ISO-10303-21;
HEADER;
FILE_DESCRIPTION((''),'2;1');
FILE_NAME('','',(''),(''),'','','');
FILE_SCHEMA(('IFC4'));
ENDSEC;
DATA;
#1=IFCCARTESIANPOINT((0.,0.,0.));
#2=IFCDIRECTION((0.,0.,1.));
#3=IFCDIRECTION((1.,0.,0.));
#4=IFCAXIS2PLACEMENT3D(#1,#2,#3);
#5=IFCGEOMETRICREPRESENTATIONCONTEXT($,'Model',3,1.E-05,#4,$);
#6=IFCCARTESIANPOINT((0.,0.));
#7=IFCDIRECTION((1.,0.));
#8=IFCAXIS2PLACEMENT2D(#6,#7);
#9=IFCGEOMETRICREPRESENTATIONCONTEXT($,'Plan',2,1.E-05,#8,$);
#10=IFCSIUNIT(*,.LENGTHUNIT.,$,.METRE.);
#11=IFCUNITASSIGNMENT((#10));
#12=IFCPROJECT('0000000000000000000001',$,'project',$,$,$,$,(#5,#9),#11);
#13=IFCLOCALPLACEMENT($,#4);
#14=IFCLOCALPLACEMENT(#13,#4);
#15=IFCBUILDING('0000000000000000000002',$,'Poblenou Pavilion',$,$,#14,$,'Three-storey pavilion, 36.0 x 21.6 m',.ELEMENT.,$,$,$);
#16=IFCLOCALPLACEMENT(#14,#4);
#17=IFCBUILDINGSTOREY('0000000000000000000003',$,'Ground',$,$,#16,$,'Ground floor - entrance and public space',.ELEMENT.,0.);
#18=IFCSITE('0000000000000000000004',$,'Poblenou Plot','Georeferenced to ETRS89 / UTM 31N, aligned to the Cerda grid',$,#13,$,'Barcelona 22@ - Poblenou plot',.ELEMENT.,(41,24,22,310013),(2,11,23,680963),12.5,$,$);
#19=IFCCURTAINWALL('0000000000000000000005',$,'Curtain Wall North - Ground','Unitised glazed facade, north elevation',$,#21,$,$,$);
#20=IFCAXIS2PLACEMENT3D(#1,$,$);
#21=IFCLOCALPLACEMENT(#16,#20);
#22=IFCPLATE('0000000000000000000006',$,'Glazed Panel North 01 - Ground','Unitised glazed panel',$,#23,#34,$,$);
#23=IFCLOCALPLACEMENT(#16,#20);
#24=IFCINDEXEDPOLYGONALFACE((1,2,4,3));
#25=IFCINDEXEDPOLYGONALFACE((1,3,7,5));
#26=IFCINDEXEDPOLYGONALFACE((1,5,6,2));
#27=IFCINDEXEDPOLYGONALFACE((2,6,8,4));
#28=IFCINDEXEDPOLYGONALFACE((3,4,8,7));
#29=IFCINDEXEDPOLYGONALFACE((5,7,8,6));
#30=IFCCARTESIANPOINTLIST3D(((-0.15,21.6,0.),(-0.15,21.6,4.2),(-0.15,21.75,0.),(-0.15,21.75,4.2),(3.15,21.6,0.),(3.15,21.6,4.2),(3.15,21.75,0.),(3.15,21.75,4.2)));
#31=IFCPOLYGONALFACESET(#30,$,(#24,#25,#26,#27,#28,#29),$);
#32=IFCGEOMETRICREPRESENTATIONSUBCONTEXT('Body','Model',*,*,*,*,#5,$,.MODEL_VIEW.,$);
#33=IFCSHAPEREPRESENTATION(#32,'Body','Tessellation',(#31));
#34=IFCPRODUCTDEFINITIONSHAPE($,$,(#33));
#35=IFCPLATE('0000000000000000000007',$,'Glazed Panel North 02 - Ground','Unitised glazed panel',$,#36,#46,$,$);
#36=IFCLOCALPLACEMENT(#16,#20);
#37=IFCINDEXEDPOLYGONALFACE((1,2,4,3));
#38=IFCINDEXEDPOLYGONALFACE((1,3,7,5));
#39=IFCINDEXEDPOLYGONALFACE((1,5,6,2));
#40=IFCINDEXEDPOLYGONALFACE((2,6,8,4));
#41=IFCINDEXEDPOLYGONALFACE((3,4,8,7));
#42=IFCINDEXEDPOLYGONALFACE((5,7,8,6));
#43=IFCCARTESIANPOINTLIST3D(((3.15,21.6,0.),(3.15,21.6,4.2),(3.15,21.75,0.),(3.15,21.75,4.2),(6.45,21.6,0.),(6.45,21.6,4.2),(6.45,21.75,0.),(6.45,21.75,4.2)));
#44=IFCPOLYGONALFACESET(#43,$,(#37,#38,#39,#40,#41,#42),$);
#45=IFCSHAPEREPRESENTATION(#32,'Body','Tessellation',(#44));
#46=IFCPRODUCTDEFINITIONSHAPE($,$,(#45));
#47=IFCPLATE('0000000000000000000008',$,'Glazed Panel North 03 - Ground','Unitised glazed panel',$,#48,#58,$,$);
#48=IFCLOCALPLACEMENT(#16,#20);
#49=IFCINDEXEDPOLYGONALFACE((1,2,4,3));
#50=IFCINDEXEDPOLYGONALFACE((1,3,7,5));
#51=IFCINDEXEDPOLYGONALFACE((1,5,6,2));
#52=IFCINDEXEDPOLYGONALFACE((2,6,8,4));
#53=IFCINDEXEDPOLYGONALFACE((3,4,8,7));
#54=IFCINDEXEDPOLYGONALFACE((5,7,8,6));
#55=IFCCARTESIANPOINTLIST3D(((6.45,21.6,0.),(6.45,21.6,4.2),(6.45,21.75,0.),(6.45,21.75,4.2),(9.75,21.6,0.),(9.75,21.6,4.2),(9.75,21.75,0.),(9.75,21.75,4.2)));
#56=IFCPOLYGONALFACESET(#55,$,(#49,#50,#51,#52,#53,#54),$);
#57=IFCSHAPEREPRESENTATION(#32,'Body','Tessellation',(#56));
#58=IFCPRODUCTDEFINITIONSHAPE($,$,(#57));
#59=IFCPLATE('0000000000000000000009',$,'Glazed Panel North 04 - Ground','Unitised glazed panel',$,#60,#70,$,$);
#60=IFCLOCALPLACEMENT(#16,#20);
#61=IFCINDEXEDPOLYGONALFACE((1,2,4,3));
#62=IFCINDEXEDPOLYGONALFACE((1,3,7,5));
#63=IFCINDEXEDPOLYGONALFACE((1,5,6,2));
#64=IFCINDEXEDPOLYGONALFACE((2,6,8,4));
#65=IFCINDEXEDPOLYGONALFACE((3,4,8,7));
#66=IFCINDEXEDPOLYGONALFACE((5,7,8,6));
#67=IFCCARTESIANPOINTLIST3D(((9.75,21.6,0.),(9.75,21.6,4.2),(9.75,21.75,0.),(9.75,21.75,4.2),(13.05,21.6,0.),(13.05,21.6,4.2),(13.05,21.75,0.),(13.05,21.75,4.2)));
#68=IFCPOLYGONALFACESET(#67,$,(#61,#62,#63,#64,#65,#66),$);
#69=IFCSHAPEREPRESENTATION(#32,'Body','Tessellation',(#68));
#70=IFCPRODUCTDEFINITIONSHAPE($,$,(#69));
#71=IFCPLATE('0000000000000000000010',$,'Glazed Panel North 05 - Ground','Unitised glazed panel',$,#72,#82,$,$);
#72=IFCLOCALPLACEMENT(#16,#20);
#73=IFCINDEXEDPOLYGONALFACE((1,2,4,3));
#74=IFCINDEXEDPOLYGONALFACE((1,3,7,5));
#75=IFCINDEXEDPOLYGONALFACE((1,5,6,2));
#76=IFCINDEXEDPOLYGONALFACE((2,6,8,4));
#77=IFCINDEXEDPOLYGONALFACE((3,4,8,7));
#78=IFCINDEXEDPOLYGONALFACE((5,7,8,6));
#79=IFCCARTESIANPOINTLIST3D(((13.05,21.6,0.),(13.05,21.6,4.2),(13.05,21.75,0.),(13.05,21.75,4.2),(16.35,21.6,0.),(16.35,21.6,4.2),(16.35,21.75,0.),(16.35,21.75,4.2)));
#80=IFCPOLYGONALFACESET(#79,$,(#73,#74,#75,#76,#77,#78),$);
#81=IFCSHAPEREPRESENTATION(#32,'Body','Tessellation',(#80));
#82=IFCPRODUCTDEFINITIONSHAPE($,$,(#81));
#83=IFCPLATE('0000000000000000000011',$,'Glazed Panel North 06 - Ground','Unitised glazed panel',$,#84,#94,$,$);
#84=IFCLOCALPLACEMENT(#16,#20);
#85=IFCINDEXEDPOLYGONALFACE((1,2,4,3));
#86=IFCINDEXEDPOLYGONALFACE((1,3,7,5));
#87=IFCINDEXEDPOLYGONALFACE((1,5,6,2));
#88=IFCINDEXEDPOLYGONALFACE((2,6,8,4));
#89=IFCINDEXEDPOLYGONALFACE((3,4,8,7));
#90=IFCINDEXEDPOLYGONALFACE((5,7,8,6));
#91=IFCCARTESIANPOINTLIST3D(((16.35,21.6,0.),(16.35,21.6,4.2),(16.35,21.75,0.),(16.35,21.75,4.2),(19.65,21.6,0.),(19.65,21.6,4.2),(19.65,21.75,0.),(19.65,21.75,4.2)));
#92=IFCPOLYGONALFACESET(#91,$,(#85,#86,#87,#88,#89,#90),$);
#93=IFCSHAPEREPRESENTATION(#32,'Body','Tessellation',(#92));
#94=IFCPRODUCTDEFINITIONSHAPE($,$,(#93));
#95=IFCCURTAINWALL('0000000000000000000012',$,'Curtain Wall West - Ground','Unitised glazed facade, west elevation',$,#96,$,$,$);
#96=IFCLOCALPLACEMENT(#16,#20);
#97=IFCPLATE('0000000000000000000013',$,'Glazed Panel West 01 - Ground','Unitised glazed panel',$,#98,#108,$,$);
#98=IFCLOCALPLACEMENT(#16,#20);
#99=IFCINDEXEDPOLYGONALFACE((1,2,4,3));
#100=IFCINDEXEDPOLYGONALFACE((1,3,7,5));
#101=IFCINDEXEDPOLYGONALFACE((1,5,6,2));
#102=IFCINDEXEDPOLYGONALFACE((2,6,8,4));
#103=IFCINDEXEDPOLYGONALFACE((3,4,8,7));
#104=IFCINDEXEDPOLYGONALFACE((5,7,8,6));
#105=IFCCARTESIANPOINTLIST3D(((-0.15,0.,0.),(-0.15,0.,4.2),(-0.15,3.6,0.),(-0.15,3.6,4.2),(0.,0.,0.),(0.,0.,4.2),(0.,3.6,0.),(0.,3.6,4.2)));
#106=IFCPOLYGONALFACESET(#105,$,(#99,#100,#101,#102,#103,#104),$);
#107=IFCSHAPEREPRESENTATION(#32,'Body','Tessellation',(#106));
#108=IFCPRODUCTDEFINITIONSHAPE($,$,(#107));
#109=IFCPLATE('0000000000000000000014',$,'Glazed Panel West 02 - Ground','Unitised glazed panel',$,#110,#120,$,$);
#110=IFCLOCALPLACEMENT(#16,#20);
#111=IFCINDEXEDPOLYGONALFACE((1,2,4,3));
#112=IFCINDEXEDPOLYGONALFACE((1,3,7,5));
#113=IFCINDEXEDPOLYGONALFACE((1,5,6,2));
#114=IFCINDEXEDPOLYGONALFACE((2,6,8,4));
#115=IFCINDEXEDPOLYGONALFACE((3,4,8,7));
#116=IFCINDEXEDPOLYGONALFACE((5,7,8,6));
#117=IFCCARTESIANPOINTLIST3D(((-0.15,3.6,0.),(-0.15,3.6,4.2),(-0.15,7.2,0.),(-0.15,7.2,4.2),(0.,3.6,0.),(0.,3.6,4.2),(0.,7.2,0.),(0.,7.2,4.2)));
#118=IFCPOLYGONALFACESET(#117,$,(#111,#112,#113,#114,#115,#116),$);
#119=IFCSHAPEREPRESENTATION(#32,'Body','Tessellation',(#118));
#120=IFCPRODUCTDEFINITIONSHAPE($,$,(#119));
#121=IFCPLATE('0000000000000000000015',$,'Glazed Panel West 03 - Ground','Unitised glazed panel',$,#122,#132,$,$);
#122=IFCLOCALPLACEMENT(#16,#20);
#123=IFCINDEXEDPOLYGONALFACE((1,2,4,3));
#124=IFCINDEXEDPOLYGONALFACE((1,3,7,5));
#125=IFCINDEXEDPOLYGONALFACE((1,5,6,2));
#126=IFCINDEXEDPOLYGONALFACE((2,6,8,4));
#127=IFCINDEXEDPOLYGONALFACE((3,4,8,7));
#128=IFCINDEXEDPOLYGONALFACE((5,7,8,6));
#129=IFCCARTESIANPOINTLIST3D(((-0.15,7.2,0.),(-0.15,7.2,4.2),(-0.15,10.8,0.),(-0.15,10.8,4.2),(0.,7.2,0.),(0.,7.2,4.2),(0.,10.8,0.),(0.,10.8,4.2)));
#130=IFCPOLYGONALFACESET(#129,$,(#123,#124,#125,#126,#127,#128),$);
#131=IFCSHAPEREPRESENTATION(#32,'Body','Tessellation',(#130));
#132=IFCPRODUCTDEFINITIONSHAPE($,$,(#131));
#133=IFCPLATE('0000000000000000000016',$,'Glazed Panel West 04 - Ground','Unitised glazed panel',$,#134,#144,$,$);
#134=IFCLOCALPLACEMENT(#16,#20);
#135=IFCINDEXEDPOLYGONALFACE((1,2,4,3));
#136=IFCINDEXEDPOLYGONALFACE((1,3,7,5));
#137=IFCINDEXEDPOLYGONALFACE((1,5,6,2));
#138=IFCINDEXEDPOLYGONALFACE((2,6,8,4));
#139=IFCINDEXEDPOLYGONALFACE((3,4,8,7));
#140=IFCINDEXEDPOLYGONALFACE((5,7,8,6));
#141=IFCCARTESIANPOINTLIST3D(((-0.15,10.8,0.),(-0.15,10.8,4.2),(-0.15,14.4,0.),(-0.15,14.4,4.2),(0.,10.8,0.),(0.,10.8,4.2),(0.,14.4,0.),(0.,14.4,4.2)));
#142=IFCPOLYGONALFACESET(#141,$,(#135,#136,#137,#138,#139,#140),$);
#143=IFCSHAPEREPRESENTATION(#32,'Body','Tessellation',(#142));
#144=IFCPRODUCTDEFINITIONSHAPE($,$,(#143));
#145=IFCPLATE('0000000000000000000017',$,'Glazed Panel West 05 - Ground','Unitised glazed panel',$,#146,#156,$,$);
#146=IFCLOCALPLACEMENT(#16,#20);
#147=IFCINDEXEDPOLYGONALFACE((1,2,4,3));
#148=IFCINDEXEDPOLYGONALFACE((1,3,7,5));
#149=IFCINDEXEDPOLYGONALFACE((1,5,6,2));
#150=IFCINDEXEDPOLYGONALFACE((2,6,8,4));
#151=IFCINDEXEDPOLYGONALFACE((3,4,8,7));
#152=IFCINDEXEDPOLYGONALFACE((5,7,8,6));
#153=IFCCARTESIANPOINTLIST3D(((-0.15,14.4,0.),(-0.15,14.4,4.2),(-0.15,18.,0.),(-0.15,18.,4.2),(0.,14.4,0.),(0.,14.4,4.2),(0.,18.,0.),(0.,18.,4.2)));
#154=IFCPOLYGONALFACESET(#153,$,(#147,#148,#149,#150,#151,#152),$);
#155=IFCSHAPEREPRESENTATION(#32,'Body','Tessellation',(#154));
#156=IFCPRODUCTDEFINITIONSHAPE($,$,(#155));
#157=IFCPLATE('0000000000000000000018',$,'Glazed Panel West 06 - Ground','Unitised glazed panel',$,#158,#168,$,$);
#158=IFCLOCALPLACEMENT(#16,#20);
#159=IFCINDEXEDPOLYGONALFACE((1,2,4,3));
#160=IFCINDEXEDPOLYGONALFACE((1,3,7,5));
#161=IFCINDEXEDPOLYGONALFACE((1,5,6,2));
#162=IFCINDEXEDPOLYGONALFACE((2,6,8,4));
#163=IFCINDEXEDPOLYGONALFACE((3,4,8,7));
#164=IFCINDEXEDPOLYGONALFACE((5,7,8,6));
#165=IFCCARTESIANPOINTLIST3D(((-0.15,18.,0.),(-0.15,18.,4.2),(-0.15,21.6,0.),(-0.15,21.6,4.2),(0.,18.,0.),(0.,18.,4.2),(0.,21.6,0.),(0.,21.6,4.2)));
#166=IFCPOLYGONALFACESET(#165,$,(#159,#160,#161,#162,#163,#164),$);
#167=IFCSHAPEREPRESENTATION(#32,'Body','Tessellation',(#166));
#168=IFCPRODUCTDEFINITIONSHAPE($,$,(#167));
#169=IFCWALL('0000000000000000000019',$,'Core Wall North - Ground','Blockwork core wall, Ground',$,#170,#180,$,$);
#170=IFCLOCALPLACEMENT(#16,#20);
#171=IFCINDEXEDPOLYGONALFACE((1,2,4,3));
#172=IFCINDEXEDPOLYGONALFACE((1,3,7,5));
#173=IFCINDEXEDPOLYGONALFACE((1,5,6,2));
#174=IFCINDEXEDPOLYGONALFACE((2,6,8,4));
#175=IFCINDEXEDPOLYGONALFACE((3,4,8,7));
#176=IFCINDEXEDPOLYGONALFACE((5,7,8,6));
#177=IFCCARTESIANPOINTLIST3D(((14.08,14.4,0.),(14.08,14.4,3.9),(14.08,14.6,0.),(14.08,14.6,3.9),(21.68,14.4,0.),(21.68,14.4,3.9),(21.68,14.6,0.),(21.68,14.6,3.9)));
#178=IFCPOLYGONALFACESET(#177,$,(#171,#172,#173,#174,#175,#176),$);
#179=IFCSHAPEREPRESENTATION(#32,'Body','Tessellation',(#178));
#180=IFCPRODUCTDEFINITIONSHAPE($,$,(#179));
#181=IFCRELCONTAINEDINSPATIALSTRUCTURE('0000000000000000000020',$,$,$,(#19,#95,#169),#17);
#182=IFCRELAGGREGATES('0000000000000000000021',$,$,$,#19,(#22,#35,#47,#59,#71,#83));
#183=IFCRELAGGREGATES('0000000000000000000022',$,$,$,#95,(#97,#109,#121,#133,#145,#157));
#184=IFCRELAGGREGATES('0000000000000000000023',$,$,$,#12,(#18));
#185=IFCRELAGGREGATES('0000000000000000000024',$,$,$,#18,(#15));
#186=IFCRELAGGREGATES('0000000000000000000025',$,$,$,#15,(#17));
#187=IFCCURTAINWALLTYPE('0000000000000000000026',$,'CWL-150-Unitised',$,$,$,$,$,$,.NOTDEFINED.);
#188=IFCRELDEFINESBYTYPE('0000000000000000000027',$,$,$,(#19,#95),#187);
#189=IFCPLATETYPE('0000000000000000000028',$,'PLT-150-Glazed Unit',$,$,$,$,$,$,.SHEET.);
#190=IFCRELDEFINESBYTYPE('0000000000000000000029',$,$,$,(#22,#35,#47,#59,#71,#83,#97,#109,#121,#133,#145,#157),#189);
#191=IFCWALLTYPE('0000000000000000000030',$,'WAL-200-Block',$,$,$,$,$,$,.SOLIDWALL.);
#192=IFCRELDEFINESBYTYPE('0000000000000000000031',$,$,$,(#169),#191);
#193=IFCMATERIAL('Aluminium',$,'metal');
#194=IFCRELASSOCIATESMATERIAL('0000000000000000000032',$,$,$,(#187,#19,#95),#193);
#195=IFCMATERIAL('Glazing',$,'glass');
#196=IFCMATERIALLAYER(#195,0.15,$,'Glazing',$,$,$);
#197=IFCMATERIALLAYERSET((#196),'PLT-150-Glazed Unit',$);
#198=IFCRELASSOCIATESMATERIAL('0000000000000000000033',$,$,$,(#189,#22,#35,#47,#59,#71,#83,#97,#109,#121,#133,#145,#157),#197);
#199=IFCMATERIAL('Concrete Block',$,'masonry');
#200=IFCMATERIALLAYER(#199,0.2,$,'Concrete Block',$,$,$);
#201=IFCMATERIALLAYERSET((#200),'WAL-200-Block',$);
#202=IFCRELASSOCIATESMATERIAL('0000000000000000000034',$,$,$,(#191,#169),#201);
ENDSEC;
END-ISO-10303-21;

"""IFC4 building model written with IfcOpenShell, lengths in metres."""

from ifc_helpers import new_model, si_unit, frame, origin_with_axes, origin_2d_with_axis, place, context, subcontext, project, spatial, line, indexed_curve, outline, extrude, material, layer, layer_set, layer_usage, type_object, element, aggregate, save


model = new_model("IFC4")

# Units and contexts
model_context = context("Model", 3, precision=1e-05, world=origin_with_axes())
plan_context = context("Plan", 2, precision=1e-05, world=origin_2d_with_axis())
body_context = subcontext(model_context, "Body", "Model", "MODEL_VIEW")
ifc_project = project(units=[si_unit("LENGTHUNIT", "METRE")], contexts=[model_context, plan_context])

# Site, building, storey
site_placement = place(None, origin_with_axes())
site = spatial("IfcSite", under=ifc_project, at=site_placement, Name="Poblenou Plot", Description="Georeferenced to ETRS89 / UTM 31N, aligned to the Cerda grid", LongName="Barcelona 22@ - Poblenou plot", CompositionType="ELEMENT", RefLatitude=(41, 24, 22, 310013), RefLongitude=(2, 11, 23, 680963), RefElevation=12.5)
building_placement = place(site_placement, origin_with_axes())
building = spatial("IfcBuilding", under=site, at=building_placement, Name="Poblenou Pavilion", LongName="Three-storey pavilion, 36.0 x 21.6 m", CompositionType="ELEMENT")
storey_placement = place(building_placement, origin_with_axes())
storey = spatial("IfcBuildingStorey", under=building, at=storey_placement, Name="Ground", LongName="Ground floor - entrance and public space", CompositionType="ELEMENT", Elevation=0.0)

# Curtain walls, plates
ifc_material_1 = material(Name="Aluminium", Category="metal")
curtain_wall_type = type_object("IfcCurtainWallType", Name="CWL-150-Unitised", PredefinedType="NOTDEFINED", material=ifc_material_1)
ifc_material_2 = material(Name="Glazing", Category="glass")
ifc_layer_1 = layer(ifc_material_2, 0.15, Name="Glazing")
ifc_layer_set_1 = layer_set([ifc_layer_1], Name="PLT-150-Glazed Unit")
plate_type = type_object("IfcPlateType", Name="PLT-150-Glazed Unit", PredefinedType="SHEET", material=ifc_layer_set_1)
curtain_wall_1_placement = place(storey_placement, frame((-0.15, 21.6, 0.0), z_axis=(0.0, 0.0, 1.0), x_axis=(1.0, 0.0, 0.0)))
curtain_wall_1 = element("IfcCurtainWall", 1, at=curtain_wall_1_placement, inside=storey, type_object=curtain_wall_type, material=ifc_material_1, Name="Curtain Wall North - Ground", Description="Unitised glazed facade, north elevation")
ifc_layer_usage_1 = layer_usage(ifc_layer_set_1, "AXIS2", "POSITIVE", 0.0)
plate_1_placement = place(curtain_wall_1_placement, origin_with_axes())
plate_1 = element("IfcPlate", 2, at=plate_1_placement, type_object=plate_type, material=ifc_layer_usage_1, Name="Glazed Panel North 01 - Ground", Description="Unitised glazed panel", context=body_context, shape_type="SweptSolid", body=[
    extrude(outline(indexed_curve([(0.0, 0.0), (3.3, 0.0), (3.3, 0.15), (0.0, 0.15)], segments=[line(1, 2, 3, 4, 1)])), origin_with_axes(), (0.0, 0.0, 1.0), 4.2),
])
ifc_layer_usage_2 = layer_usage(ifc_layer_set_1, "AXIS2", "POSITIVE", 0.0)
plate_2_placement = place(curtain_wall_1_placement, frame((3.3, 0.0, 0.0), z_axis=(0.0, 0.0, 1.0), x_axis=(1.0, 0.0, 0.0)))
plate_2 = element("IfcPlate", 3, at=plate_2_placement, type_object=plate_type, material=ifc_layer_usage_2, Name="Glazed Panel North 02 - Ground", Description="Unitised glazed panel", context=body_context, shape_type="SweptSolid", body=[
    extrude(outline(indexed_curve([(0.0, 0.0), (3.3, 0.0), (3.3, 0.15), (0.0, 0.15)], segments=[line(1, 2, 3, 4, 1)])), origin_with_axes(), (0.0, 0.0, 1.0), 4.2),
])
ifc_layer_usage_3 = layer_usage(ifc_layer_set_1, "AXIS2", "POSITIVE", 0.0)
plate_3_placement = place(curtain_wall_1_placement, frame((6.6, 0.0, 0.0), z_axis=(0.0, 0.0, 1.0), x_axis=(1.0, 0.0, 0.0)))
plate_3 = element("IfcPlate", 4, at=plate_3_placement, type_object=plate_type, material=ifc_layer_usage_3, Name="Glazed Panel North 03 - Ground", Description="Unitised glazed panel", context=body_context, shape_type="SweptSolid", body=[
    extrude(outline(indexed_curve([(0.0, 0.0), (3.3, 0.0), (3.3, 0.15), (0.0, 0.15)], segments=[line(1, 2, 3, 4, 1)])), origin_with_axes(), (0.0, 0.0, 1.0), 4.2),
])
ifc_layer_usage_4 = layer_usage(ifc_layer_set_1, "AXIS2", "POSITIVE", 0.0)
plate_4_placement = place(curtain_wall_1_placement, frame((9.9, 0.0, 0.0), z_axis=(0.0, 0.0, 1.0), x_axis=(1.0, 0.0, 0.0)))
plate_4 = element("IfcPlate", 5, at=plate_4_placement, type_object=plate_type, material=ifc_layer_usage_4, Name="Glazed Panel North 04 - Ground", Description="Unitised glazed panel", context=body_context, shape_type="SweptSolid", body=[
    extrude(outline(indexed_curve([(0.0, 0.0), (3.3, 0.0), (3.3, 0.15), (0.0, 0.15)], segments=[line(1, 2, 3, 4, 1)])), origin_with_axes(), (0.0, 0.0, 1.0), 4.2),
])
ifc_layer_usage_5 = layer_usage(ifc_layer_set_1, "AXIS2", "POSITIVE", 0.0)
plate_5_placement = place(curtain_wall_1_placement, frame((13.2, 0.0, 0.0), z_axis=(0.0, 0.0, 1.0), x_axis=(1.0, 0.0, 0.0)))
plate_5 = element("IfcPlate", 6, at=plate_5_placement, type_object=plate_type, material=ifc_layer_usage_5, Name="Glazed Panel North 05 - Ground", Description="Unitised glazed panel", context=body_context, shape_type="SweptSolid", body=[
    extrude(outline(indexed_curve([(0.0, 0.0), (3.3, 0.0), (3.3, 0.15), (0.0, 0.15)], segments=[line(1, 2, 3, 4, 1)])), origin_with_axes(), (0.0, 0.0, 1.0), 4.2),
])
ifc_layer_usage_6 = layer_usage(ifc_layer_set_1, "AXIS2", "POSITIVE", 0.0)
plate_6_placement = place(curtain_wall_1_placement, frame((16.5, 0.0, 0.0), z_axis=(0.0, 0.0, 1.0), x_axis=(1.0, 0.0, 0.0)))
plate_6 = element("IfcPlate", 7, at=plate_6_placement, type_object=plate_type, material=ifc_layer_usage_6, Name="Glazed Panel North 06 - Ground", Description="Unitised glazed panel", context=body_context, shape_type="SweptSolid", body=[
    extrude(outline(indexed_curve([(0.0, 0.0), (3.3, 0.0), (3.3, 0.15), (0.0, 0.15)], segments=[line(1, 2, 3, 4, 1)])), origin_with_axes(), (0.0, 0.0, 1.0), 4.2),
])
aggregate(curtain_wall_1, [plate_1, plate_2, plate_3, plate_4, plate_5, plate_6])
curtain_wall_2_placement = place(storey_placement, frame((0.0, 0.0, 0.0), z_axis=(0.0, 0.0, 1.0), x_axis=(0.0, 1.0, 0.0)))
curtain_wall_2 = element("IfcCurtainWall", 8, at=curtain_wall_2_placement, inside=storey, type_object=curtain_wall_type, material=ifc_material_1, Name="Curtain Wall West - Ground", Description="Unitised glazed facade, west elevation")
ifc_layer_usage_7 = layer_usage(ifc_layer_set_1, "AXIS2", "POSITIVE", 0.0)
plate_7_placement = place(curtain_wall_2_placement, origin_with_axes())
plate_7 = element("IfcPlate", 9, at=plate_7_placement, type_object=plate_type, material=ifc_layer_usage_7, Name="Glazed Panel West 01 - Ground", Description="Unitised glazed panel", context=body_context, shape_type="SweptSolid", body=[
    extrude(outline(indexed_curve([(0.0, 0.0), (3.6, 0.0), (3.6, 0.15), (0.0, 0.15)], segments=[line(1, 2, 3, 4, 1)])), origin_with_axes(), (0.0, 0.0, 1.0), 4.2),
])
ifc_layer_usage_8 = layer_usage(ifc_layer_set_1, "AXIS2", "POSITIVE", 0.0)
plate_8_placement = place(curtain_wall_2_placement, frame((3.6, 0.0, 0.0), z_axis=(0.0, 0.0, 1.0), x_axis=(1.0, 0.0, 0.0)))
plate_8 = element("IfcPlate", 10, at=plate_8_placement, type_object=plate_type, material=ifc_layer_usage_8, Name="Glazed Panel West 02 - Ground", Description="Unitised glazed panel", context=body_context, shape_type="SweptSolid", body=[
    extrude(outline(indexed_curve([(0.0, 0.0), (3.6, 0.0), (3.6, 0.15), (0.0, 0.15)], segments=[line(1, 2, 3, 4, 1)])), origin_with_axes(), (0.0, 0.0, 1.0), 4.2),
])
ifc_layer_usage_9 = layer_usage(ifc_layer_set_1, "AXIS2", "POSITIVE", 0.0)
plate_9_placement = place(curtain_wall_2_placement, frame((7.2, 0.0, 0.0), z_axis=(0.0, 0.0, 1.0), x_axis=(1.0, 0.0, 0.0)))
plate_9 = element("IfcPlate", 11, at=plate_9_placement, type_object=plate_type, material=ifc_layer_usage_9, Name="Glazed Panel West 03 - Ground", Description="Unitised glazed panel", context=body_context, shape_type="SweptSolid", body=[
    extrude(outline(indexed_curve([(0.0, 0.0), (3.6, 0.0), (3.6, 0.15), (0.0, 0.15)], segments=[line(1, 2, 3, 4, 1)])), origin_with_axes(), (0.0, 0.0, 1.0), 4.2),
])
ifc_layer_usage_10 = layer_usage(ifc_layer_set_1, "AXIS2", "POSITIVE", 0.0)
plate_10_placement = place(curtain_wall_2_placement, frame((10.8, 0.0, 0.0), z_axis=(0.0, 0.0, 1.0), x_axis=(1.0, 0.0, 0.0)))
plate_10 = element("IfcPlate", 12, at=plate_10_placement, type_object=plate_type, material=ifc_layer_usage_10, Name="Glazed Panel West 04 - Ground", Description="Unitised glazed panel", context=body_context, shape_type="SweptSolid", body=[
    extrude(outline(indexed_curve([(0.0, 0.0), (3.6, 0.0), (3.6, 0.15), (0.0, 0.15)], segments=[line(1, 2, 3, 4, 1)])), origin_with_axes(), (0.0, 0.0, 1.0), 4.2),
])
ifc_layer_usage_11 = layer_usage(ifc_layer_set_1, "AXIS2", "POSITIVE", 0.0)
plate_11_placement = place(curtain_wall_2_placement, frame((14.4, 0.0, 0.0), z_axis=(0.0, 0.0, 1.0), x_axis=(1.0, 0.0, 0.0)))
plate_11 = element("IfcPlate", 13, at=plate_11_placement, type_object=plate_type, material=ifc_layer_usage_11, Name="Glazed Panel West 05 - Ground", Description="Unitised glazed panel", context=body_context, shape_type="SweptSolid", body=[
    extrude(outline(indexed_curve([(0.0, 0.0), (3.6, 0.0), (3.6, 0.15), (0.0, 0.15)], segments=[line(1, 2, 3, 4, 1)])), origin_with_axes(), (0.0, 0.0, 1.0), 4.2),
])
ifc_layer_usage_12 = layer_usage(ifc_layer_set_1, "AXIS2", "POSITIVE", 0.0)
plate_12_placement = place(curtain_wall_2_placement, frame((18.0, 0.0, 0.0), z_axis=(0.0, 0.0, 1.0), x_axis=(1.0, 0.0, 0.0)))
plate_12 = element("IfcPlate", 14, at=plate_12_placement, type_object=plate_type, material=ifc_layer_usage_12, Name="Glazed Panel West 06 - Ground", Description="Unitised glazed panel", context=body_context, shape_type="SweptSolid", body=[
    extrude(outline(indexed_curve([(0.0, 0.0), (3.6, 0.0), (3.6, 0.15), (0.0, 0.15)], segments=[line(1, 2, 3, 4, 1)])), origin_with_axes(), (0.0, 0.0, 1.0), 4.2),
])
aggregate(curtain_wall_2, [plate_7, plate_8, plate_9, plate_10, plate_11, plate_12])

# Wall
ifc_material_3 = material(Name="Concrete Block", Category="masonry")
ifc_layer_2 = layer(ifc_material_3, 0.2, Name="Concrete Block")
ifc_layer_set_2 = layer_set([ifc_layer_2], Name="WAL-200-Block")
ifc_layer_usage_13 = layer_usage(ifc_layer_set_2, "AXIS2", "POSITIVE", 0.0)
wall_type = type_object("IfcWallType", Name="WAL-200-Block", PredefinedType="SOLIDWALL", material=ifc_layer_set_2)
wall_1_placement = place(storey_placement, frame((14.08, 14.4, 0.0), z_axis=(0.0, 0.0, 1.0), x_axis=(1.0, 0.0, 0.0)))
element("IfcWall", 15, at=wall_1_placement, inside=storey, type_object=wall_type, material=ifc_layer_usage_13, Name="Core Wall North - Ground", Description="Blockwork core wall, Ground", context=body_context, shape_type="SweptSolid", body=[
    extrude(outline(indexed_curve([(0.0, 0.0), (7.6, 0.0), (7.6, 0.2), (0.0, 0.2)], segments=[line(1, 2, 3, 4, 1)])), origin_with_axes(), (0.0, 0.0, 1.0), 3.9),
])

save(model, "model.ifc")
